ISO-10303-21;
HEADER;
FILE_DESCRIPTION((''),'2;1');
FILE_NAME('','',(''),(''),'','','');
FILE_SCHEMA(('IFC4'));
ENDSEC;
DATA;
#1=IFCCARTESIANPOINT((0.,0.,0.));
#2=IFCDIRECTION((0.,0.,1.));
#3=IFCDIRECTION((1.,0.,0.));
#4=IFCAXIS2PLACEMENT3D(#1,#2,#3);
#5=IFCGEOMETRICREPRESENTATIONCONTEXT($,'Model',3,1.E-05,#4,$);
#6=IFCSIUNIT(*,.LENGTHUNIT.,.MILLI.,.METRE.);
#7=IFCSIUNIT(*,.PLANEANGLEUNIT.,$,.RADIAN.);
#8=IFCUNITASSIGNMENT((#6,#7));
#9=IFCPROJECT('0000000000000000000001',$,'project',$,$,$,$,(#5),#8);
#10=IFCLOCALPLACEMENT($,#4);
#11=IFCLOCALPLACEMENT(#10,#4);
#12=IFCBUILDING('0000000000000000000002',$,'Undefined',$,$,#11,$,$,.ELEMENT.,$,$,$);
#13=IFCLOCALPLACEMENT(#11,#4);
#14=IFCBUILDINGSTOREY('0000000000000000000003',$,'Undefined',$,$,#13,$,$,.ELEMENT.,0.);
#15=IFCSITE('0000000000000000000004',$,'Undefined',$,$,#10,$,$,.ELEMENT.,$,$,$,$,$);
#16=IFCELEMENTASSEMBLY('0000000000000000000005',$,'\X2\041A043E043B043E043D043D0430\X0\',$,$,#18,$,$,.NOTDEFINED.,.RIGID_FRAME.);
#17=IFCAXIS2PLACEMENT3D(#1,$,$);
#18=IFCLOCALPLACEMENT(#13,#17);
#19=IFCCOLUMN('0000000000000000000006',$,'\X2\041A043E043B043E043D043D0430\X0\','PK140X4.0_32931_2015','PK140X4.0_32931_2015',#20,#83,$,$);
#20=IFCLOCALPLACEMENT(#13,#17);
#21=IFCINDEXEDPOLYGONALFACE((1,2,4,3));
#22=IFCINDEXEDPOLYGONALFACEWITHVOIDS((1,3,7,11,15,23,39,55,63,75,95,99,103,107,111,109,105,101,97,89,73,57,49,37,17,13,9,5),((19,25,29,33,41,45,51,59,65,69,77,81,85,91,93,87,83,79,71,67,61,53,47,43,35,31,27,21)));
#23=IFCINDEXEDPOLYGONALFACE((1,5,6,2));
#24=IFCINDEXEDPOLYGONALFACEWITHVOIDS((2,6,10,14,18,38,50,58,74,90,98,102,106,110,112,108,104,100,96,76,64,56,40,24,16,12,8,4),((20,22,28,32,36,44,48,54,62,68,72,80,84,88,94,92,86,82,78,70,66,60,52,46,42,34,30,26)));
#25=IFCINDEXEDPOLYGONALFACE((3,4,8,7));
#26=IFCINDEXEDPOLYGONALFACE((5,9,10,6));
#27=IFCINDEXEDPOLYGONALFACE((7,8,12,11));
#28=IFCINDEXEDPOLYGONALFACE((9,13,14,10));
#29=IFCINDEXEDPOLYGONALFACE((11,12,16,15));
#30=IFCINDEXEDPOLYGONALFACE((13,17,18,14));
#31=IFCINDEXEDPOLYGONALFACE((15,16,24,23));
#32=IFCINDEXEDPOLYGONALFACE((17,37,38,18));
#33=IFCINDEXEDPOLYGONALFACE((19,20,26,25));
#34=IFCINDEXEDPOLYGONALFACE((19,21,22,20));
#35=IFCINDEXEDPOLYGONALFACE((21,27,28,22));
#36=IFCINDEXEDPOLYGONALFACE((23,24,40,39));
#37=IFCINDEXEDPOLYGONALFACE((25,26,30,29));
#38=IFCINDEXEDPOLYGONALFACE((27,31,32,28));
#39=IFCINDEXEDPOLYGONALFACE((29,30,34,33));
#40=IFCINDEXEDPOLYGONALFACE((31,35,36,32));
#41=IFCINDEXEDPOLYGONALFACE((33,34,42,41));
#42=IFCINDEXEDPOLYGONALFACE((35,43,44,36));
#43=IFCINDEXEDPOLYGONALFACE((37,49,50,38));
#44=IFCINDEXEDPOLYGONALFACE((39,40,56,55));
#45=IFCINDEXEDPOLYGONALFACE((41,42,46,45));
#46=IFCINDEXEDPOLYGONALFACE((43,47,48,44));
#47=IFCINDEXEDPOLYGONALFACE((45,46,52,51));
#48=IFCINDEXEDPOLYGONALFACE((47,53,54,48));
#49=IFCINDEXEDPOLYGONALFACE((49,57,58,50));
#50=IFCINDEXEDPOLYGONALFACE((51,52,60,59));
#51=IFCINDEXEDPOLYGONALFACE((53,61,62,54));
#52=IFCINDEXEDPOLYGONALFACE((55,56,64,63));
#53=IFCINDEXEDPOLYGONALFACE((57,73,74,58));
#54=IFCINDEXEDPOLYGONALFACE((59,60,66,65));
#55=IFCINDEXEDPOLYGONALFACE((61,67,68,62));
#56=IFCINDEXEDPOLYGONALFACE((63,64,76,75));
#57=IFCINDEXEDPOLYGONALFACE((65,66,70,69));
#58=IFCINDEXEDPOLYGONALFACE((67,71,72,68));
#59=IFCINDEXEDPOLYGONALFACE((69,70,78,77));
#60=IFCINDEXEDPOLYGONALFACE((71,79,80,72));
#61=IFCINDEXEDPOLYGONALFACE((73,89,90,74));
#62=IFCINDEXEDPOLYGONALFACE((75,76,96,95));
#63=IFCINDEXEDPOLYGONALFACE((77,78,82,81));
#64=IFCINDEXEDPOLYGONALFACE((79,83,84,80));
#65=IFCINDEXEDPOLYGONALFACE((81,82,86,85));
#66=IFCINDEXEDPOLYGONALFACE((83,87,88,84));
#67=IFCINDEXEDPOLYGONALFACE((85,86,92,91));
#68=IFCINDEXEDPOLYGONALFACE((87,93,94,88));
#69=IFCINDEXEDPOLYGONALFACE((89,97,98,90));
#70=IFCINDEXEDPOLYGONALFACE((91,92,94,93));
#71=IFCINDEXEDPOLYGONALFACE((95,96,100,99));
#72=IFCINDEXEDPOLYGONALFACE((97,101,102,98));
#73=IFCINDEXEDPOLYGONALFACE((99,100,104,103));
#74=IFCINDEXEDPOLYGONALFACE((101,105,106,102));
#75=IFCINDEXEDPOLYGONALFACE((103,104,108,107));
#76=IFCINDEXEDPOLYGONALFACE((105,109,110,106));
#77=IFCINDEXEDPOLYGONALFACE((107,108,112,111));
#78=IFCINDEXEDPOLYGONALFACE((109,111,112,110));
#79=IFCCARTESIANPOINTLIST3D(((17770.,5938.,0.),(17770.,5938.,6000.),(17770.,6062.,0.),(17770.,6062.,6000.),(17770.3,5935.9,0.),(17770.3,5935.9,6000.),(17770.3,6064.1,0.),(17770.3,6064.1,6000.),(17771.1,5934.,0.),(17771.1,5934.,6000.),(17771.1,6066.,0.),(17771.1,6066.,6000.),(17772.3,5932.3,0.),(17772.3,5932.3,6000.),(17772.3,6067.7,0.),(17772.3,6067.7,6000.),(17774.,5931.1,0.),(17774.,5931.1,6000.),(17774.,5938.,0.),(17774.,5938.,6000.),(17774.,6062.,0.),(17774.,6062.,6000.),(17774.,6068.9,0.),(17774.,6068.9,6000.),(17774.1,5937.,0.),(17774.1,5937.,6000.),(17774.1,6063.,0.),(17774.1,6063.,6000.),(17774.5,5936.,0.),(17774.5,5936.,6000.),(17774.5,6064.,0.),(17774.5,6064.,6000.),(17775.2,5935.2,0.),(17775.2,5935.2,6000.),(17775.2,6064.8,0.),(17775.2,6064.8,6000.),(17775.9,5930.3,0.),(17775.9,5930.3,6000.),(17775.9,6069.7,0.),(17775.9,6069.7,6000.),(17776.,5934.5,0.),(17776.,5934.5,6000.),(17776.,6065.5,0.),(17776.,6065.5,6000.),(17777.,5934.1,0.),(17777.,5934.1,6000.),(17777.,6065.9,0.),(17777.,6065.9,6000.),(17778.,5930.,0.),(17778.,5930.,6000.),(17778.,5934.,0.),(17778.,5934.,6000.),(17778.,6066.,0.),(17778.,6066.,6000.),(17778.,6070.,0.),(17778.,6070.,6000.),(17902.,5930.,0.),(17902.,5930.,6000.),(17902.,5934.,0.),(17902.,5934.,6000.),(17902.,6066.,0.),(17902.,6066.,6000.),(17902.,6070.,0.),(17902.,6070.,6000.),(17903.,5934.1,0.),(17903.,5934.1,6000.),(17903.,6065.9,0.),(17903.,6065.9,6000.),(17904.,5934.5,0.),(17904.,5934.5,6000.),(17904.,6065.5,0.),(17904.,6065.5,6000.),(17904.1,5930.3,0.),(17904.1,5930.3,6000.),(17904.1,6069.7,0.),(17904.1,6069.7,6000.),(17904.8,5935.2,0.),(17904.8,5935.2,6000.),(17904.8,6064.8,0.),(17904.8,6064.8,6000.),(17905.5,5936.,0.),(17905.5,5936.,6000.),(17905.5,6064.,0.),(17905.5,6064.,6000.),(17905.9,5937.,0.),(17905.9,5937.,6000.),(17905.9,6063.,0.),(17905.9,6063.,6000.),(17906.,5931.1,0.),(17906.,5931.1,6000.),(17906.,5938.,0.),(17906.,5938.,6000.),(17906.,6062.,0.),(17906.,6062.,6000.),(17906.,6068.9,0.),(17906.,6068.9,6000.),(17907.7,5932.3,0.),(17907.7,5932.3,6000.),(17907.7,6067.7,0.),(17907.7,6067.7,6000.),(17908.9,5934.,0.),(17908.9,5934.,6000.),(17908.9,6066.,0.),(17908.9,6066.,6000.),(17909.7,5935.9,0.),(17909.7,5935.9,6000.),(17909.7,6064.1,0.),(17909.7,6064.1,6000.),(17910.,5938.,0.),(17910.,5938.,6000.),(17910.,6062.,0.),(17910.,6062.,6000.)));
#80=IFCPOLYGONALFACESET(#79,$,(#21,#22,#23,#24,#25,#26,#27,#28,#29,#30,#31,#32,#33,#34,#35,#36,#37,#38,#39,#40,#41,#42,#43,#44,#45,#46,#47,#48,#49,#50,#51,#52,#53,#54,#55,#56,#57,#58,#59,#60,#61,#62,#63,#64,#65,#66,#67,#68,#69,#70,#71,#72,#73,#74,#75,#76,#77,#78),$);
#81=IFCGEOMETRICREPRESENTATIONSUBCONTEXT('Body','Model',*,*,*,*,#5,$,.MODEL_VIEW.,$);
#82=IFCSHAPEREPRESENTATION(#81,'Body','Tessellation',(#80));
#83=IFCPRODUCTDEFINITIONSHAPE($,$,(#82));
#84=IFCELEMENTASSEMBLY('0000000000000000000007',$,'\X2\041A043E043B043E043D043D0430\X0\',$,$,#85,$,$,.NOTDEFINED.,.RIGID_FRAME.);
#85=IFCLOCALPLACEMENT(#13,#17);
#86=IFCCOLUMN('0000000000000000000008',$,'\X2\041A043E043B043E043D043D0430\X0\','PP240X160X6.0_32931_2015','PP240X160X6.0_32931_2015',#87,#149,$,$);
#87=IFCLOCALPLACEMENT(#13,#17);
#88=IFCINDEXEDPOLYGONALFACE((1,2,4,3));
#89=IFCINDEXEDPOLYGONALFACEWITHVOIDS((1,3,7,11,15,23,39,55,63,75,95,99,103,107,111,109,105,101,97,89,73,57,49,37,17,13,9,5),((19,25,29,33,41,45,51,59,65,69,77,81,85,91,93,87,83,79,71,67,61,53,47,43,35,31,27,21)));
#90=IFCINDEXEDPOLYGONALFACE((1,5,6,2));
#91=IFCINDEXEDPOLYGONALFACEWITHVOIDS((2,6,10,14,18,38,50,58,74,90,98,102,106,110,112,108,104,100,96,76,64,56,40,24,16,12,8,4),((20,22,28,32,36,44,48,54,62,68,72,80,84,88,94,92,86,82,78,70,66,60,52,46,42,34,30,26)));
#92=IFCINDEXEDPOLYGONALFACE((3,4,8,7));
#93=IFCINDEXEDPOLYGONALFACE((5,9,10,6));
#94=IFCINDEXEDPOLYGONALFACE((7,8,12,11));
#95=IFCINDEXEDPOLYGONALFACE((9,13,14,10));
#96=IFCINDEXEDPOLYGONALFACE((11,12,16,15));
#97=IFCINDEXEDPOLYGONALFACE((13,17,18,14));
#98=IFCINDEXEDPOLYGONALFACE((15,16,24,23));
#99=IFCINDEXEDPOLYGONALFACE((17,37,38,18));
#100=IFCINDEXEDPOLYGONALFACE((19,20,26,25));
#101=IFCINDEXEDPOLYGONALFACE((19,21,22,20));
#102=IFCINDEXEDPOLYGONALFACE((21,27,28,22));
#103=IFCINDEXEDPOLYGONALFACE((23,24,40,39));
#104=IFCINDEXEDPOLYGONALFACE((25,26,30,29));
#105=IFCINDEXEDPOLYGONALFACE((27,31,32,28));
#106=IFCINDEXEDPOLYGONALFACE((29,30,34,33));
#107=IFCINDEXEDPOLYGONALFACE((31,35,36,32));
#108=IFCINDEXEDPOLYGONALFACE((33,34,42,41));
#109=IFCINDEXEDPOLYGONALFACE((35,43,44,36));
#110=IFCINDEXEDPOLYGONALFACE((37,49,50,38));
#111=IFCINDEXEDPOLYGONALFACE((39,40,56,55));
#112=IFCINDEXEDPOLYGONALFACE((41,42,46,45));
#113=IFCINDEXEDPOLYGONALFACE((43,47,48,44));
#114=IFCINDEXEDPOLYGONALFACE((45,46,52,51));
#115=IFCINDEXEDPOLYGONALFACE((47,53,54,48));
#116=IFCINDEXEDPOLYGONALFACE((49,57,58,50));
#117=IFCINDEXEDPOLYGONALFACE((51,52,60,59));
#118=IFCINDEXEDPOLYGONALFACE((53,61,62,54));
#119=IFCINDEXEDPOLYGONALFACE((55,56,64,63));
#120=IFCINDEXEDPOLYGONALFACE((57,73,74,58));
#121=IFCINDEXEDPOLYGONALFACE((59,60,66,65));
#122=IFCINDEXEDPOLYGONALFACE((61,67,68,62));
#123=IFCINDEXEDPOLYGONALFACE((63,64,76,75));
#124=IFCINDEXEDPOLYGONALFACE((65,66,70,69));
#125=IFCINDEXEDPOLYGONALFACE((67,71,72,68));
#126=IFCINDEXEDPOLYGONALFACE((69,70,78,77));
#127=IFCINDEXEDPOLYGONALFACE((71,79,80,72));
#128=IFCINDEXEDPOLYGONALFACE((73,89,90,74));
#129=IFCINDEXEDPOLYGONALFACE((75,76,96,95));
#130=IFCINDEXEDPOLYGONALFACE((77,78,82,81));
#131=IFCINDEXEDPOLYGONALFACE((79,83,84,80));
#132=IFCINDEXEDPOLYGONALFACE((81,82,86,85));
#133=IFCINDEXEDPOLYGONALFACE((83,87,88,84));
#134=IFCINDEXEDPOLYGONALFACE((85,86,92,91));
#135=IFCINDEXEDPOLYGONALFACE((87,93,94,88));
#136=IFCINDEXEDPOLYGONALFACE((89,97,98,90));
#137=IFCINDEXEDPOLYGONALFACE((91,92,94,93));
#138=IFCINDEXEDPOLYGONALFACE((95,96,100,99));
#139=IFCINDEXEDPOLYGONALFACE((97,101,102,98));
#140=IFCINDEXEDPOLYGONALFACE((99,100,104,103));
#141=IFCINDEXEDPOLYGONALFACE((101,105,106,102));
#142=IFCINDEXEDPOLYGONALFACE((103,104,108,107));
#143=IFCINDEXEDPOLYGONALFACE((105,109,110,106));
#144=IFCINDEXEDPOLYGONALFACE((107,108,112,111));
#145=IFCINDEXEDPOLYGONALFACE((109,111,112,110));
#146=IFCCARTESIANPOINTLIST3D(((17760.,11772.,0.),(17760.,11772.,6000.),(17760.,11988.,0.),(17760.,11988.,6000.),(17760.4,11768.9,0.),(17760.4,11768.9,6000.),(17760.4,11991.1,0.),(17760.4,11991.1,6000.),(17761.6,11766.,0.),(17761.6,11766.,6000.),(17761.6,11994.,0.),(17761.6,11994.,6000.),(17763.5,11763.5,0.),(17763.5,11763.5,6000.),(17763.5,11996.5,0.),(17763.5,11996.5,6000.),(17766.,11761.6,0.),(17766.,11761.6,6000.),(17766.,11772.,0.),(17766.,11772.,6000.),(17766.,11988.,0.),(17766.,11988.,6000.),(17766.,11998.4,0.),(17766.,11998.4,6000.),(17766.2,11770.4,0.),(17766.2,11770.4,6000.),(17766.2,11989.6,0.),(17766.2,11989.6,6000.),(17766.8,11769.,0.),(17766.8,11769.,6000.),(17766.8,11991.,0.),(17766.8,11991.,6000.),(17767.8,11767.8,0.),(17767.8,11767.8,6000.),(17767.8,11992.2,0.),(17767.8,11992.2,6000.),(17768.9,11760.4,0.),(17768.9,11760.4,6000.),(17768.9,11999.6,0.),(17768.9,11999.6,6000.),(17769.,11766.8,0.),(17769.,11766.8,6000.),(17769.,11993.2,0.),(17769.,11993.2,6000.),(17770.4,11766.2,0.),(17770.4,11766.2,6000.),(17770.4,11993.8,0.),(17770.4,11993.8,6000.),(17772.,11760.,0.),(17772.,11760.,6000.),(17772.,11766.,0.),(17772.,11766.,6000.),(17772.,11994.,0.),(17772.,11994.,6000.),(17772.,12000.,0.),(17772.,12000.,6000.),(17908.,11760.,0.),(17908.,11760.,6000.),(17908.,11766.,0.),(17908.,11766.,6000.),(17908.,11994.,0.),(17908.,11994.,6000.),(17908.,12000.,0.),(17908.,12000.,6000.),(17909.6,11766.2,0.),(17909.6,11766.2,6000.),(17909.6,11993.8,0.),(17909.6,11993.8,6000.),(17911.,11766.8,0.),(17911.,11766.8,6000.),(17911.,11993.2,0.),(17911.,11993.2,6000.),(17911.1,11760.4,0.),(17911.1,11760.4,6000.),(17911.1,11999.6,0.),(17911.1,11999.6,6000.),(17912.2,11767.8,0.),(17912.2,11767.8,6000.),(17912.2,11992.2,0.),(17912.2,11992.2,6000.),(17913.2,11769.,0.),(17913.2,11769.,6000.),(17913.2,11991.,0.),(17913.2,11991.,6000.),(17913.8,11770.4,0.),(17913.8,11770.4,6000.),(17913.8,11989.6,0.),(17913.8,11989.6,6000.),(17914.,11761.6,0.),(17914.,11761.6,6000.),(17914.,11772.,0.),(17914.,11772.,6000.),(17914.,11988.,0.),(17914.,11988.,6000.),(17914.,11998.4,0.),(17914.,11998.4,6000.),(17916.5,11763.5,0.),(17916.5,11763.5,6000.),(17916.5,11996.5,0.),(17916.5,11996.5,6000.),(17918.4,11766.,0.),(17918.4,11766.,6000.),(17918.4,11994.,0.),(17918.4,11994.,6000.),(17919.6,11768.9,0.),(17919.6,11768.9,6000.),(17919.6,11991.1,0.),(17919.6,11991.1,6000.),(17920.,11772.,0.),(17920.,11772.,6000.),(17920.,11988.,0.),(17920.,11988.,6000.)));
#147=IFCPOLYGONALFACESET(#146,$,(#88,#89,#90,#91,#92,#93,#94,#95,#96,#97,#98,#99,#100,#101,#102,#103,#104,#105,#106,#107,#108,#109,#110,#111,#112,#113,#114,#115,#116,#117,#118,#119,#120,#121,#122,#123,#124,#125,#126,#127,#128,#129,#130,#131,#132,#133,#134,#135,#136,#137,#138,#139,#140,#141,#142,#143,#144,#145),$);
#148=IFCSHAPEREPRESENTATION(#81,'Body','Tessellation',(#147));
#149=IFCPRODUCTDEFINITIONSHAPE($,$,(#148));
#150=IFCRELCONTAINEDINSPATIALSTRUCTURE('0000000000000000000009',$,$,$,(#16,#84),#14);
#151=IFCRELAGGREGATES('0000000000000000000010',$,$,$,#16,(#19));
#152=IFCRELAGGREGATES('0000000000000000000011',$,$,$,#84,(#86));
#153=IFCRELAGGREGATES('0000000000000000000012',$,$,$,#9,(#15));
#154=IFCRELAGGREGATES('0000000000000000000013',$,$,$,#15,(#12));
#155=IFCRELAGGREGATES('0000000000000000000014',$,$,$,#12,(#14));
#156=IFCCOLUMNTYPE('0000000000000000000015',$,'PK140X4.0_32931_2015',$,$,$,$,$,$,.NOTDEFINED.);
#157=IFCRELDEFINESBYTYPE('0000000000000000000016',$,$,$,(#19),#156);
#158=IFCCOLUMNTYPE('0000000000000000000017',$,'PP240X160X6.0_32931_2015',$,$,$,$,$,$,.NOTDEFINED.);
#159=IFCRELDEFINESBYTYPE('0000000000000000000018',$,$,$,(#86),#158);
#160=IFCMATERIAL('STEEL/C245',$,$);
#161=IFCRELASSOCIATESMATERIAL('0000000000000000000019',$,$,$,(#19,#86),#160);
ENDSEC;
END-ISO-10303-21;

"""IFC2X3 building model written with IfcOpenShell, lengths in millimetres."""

from ifc_helpers import new_model, si_unit, frame, origin_with_axes, origin_2d_with_axis, place, context, subcontext, project, spatial, hollow_rectangle, extrude, material, type_object, element, aggregate, save


model = new_model("IFC2X3")

# Units and contexts
model_context = context("Model", 3, precision=1e-05, world=origin_with_axes())
body_context = subcontext(model_context, "Body", "Model", "MODEL_VIEW")
ifc_project = project(units=[si_unit("LENGTHUNIT", "METRE", prefix="MILLI"), si_unit("PLANEANGLEUNIT", "RADIAN")], contexts=[model_context])

# Site, building, storey
site_placement = place(None, origin_with_axes())
site = spatial("IfcSite", under=ifc_project, at=site_placement, Name="Undefined", CompositionType="ELEMENT")
building_placement = place(site_placement, origin_with_axes())
building = spatial("IfcBuilding", under=site, at=building_placement, Name="Undefined", CompositionType="ELEMENT")
storey_placement = place(building_placement, origin_with_axes())
storey = spatial("IfcBuildingStorey", under=building, at=storey_placement, Name="Undefined", CompositionType="ELEMENT", Elevation=0.0)

# Element assemblies, columns
assembly_1_placement = place(storey_placement, origin_with_axes())
assembly_1 = element("IfcElementAssembly", 1, at=assembly_1_placement, inside=storey, Name="Колонна", AssemblyPlace="NOTDEFINED", PredefinedType="RIGID_FRAME")
ifc_material = material(Name="STEEL/C245")
column_type_1 = type_object("IfcColumnType", Name="PK140X4.0_32931_2015", PredefinedType="NOTDEFINED")
column_1_placement = place(assembly_1_placement, frame((17840.0, 6000.0, 0.0), z_axis=(0.0, 0.0, 1.0), x_axis=(0.0, 1.0, 0.0)))
column_1 = element("IfcColumn", 2, at=column_1_placement, type_object=column_type_1, material=ifc_material, Name="Колонна", Description="PK140X4.0_32931_2015", ObjectType="PK140X4.0_32931_2015", context=body_context, shape_type="SweptSolid", body=[
    extrude(hollow_rectangle(XDim=140.0, YDim=140.0, WallThickness=4.0, InnerFilletRadius=4.0, OuterFilletRadius=8.0, at=origin_2d_with_axis()), frame((0.0, 0.0, 6000.0), z_axis=(0.0, 0.0, -1.0), x_axis=(0.0, 1.0, 0.0)), (0.0, 0.0, 1.0), 6000.0),
])
aggregate(assembly_1, [column_1])
assembly_2_placement = place(storey_placement, origin_with_axes())
assembly_2 = element("IfcElementAssembly", 3, at=assembly_2_placement, inside=storey, Name="Колонна", AssemblyPlace="NOTDEFINED", PredefinedType="RIGID_FRAME")
column_type_2 = type_object("IfcColumnType", Name="PP240X160X6.0_32931_2015", PredefinedType="NOTDEFINED")
column_2_placement = place(assembly_2_placement, frame((17840.0, 11880.0, 0.0), z_axis=(0.0, 0.0, 1.0), x_axis=(0.0, -1.0, 0.0)))
column_2 = element("IfcColumn", 4, at=column_2_placement, type_object=column_type_2, material=ifc_material, Name="Колонна", Description="PP240X160X6.0_32931_2015", ObjectType="PP240X160X6.0_32931_2015", context=body_context, shape_type="SweptSolid", body=[
    extrude(hollow_rectangle(XDim=160.0, YDim=240.0, WallThickness=6.0, InnerFilletRadius=6.0, OuterFilletRadius=12.0, at=origin_2d_with_axis()), frame((0.0, 0.0, 6000.0), z_axis=(0.0, 0.0, -1.0), x_axis=(0.0, 1.0, 0.0)), (0.0, 0.0, 1.0), 6000.0),
])
aggregate(assembly_2, [column_2])

save(model, "model.ifc")
